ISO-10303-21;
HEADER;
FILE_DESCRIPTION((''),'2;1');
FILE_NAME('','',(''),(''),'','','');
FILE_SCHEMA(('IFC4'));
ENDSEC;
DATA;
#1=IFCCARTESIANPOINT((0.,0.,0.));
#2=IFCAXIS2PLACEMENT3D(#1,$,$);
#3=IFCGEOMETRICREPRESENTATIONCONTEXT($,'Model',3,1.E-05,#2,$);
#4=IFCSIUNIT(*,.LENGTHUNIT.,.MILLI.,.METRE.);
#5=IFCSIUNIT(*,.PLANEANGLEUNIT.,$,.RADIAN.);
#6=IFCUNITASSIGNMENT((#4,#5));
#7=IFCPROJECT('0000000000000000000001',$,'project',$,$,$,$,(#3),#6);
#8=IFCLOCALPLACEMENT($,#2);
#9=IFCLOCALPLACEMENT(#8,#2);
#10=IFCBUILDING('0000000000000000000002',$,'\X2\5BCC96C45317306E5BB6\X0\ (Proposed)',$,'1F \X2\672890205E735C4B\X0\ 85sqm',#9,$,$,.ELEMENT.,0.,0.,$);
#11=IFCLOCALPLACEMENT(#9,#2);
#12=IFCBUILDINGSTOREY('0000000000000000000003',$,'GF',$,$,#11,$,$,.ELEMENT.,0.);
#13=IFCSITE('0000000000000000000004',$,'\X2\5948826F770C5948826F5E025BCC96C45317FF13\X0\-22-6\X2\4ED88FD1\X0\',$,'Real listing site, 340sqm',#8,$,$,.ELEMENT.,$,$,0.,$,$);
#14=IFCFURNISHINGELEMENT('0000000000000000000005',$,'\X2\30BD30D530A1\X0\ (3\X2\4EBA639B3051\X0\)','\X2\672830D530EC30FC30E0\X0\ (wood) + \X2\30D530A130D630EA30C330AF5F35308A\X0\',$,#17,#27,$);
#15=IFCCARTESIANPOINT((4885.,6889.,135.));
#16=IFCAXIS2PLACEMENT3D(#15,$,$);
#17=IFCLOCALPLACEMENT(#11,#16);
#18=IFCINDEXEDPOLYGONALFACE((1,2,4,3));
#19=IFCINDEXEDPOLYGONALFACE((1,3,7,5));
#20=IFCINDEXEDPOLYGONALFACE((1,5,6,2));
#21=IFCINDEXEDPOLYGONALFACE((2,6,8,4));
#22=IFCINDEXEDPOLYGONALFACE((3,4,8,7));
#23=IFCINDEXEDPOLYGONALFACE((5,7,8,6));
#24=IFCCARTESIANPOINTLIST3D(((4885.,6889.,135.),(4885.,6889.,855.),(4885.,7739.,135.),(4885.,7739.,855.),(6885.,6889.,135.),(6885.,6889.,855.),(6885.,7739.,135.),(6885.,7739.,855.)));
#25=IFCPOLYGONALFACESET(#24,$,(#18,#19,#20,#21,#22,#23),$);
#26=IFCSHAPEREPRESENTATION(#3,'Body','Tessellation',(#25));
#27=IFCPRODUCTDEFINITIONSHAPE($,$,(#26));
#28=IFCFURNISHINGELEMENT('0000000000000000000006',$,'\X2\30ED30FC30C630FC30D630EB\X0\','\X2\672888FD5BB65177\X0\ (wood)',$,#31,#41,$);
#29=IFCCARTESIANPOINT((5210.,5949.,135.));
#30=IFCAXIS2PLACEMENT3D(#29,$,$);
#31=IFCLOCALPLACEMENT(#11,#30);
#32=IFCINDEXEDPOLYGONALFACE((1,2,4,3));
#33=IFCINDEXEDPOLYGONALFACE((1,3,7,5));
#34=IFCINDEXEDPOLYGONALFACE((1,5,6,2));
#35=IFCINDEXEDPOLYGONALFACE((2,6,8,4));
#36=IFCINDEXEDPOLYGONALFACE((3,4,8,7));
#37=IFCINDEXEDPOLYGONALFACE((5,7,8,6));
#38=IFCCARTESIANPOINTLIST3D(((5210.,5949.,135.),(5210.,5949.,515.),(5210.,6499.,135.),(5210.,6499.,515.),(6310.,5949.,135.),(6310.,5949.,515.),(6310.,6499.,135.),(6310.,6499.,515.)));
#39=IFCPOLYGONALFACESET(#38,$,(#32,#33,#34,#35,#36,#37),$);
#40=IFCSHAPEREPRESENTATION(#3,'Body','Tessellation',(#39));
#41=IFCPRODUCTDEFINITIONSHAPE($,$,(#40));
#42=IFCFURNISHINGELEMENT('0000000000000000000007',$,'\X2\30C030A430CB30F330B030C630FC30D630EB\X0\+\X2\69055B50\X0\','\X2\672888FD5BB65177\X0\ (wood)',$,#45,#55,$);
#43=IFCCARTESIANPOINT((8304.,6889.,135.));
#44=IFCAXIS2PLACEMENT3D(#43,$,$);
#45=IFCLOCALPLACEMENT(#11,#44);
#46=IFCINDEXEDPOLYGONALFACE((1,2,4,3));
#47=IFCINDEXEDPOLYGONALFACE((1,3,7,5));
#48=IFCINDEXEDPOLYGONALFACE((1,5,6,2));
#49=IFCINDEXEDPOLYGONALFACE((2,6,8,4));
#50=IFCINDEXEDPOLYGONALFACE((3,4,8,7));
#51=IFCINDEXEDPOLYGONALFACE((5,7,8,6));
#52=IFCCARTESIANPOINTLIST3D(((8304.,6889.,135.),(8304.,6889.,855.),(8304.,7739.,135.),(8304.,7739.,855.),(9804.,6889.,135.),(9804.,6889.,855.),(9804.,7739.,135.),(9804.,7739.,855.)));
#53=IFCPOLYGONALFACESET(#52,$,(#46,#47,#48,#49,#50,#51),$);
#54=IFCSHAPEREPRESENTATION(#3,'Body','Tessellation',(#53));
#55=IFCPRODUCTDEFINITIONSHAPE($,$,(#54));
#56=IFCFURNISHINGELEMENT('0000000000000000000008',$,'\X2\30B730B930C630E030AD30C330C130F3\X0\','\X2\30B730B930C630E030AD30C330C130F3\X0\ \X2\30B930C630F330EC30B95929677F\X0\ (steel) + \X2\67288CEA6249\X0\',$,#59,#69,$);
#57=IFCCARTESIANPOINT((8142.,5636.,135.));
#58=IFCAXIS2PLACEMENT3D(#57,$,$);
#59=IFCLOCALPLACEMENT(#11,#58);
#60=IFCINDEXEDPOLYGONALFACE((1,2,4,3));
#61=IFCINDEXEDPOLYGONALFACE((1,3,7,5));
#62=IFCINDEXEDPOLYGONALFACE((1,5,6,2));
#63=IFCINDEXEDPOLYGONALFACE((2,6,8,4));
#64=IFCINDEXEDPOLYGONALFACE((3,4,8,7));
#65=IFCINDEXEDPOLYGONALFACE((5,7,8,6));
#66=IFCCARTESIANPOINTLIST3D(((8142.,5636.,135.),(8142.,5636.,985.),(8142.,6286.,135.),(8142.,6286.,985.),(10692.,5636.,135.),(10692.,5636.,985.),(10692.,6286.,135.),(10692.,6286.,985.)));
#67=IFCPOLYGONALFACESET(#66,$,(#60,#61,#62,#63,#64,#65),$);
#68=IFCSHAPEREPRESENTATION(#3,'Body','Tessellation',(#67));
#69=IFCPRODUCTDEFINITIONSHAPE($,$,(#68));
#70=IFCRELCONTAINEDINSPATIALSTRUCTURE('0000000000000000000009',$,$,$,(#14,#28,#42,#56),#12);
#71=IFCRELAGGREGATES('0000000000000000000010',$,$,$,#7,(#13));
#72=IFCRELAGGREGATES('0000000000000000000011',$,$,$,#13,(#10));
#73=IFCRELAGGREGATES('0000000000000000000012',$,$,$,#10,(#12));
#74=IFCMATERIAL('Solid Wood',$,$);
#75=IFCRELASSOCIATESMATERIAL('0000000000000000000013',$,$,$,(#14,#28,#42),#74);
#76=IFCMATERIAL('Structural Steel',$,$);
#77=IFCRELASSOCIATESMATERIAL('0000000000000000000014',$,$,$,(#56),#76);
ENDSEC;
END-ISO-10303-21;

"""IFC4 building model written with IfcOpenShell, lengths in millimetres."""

from ifc_helpers import new_model, si_unit, frame, frame_2d, origin, place, context, project, spatial, rectangle, extrude, material, element, save


model = new_model("IFC4")

# Units and contexts
model_context = context("Model", 3, precision=1e-05, world=origin())
ifc_project = project(units=[si_unit("LENGTHUNIT", "METRE", prefix="MILLI"), si_unit("PLANEANGLEUNIT", "RADIAN")], contexts=[model_context])

# Site, building, storey
site_placement = place(None, origin())
site = spatial("IfcSite", under=ifc_project, at=site_placement, Name="奈良県奈良市富雄北３-22-6付近", ObjectType="Real listing site, 340sqm", CompositionType="ELEMENT", RefElevation=0.0)
building_placement = place(site_placement, origin())
building = spatial("IfcBuilding", under=site, at=building_placement, Name="富雄北の家 (Proposed)", ObjectType="1F 木造平屋 85sqm", CompositionType="ELEMENT", ElevationOfRefHeight=0.0, ElevationOfTerrain=0.0)
storey_placement = place(building_placement, origin())
storey = spatial("IfcBuildingStorey", under=building, at=storey_placement, Name="GF", CompositionType="ELEMENT", Elevation=0.0)

# Shared definitions
ifc_material_1 = material(Name="Solid Wood")

# Shared definitions
ifc_material_2 = material(Name="Structural Steel")

# Furnishing elements
furnishing_1_placement = place(storey_placement, frame((4885.0, 6889.0, 135.0)))
element("IfcFurnishingElement", 1, at=furnishing_1_placement, inside=storey, material=ifc_material_1, Name="ソファ (3人掛け)", Description="木フレーム (wood) + ファブリック張り", context=model_context, shape_type="SweptSolid", body=[
    extrude(rectangle(XDim=2000.0, YDim=850.0, at=frame_2d((1000.0, 425.0))), frame((4885.0, 6889.0, 135.0)), (0.0, 0.0, 1.0), 720.0),
])
furnishing_2_placement = place(storey_placement, frame((5210.0, 5949.0, 135.0)))
element("IfcFurnishingElement", 2, at=furnishing_2_placement, inside=storey, material=ifc_material_1, Name="ローテーブル", Description="木製家具 (wood)", context=model_context, shape_type="SweptSolid", body=[
    extrude(rectangle(XDim=1100.0, YDim=550.0, at=frame_2d((550.0, 275.0))), frame((5210.0, 5949.0, 135.0)), (0.0, 0.0, 1.0), 380.0),
])
furnishing_3_placement = place(storey_placement, frame((8304.0, 6889.0, 135.0)))
element("IfcFurnishingElement", 3, at=furnishing_3_placement, inside=storey, material=ifc_material_1, Name="ダイニングテーブル+椅子", Description="木製家具 (wood)", context=model_context, shape_type="SweptSolid", body=[
    extrude(rectangle(XDim=1500.0, YDim=850.0, at=frame_2d((750.0, 425.0))), frame((8304.0, 6889.0, 135.0)), (0.0, 0.0, 1.0), 720.0),
])
furnishing_4_placement = place(storey_placement, frame((8142.0, 5636.0, 135.0)))
element("IfcFurnishingElement", 4, at=furnishing_4_placement, inside=storey, material=ifc_material_2, Name="システムキッチン", Description="システムキッチン ステンレス天板 (steel) + 木質扉", context=model_context, shape_type="SweptSolid", body=[
    extrude(rectangle(XDim=2550.0, YDim=650.0, at=frame_2d((1275.0, 325.0))), frame((8142.0, 5636.0, 135.0)), (0.0, 0.0, 1.0), 850.0),
])

save(model, "model.ifc")
